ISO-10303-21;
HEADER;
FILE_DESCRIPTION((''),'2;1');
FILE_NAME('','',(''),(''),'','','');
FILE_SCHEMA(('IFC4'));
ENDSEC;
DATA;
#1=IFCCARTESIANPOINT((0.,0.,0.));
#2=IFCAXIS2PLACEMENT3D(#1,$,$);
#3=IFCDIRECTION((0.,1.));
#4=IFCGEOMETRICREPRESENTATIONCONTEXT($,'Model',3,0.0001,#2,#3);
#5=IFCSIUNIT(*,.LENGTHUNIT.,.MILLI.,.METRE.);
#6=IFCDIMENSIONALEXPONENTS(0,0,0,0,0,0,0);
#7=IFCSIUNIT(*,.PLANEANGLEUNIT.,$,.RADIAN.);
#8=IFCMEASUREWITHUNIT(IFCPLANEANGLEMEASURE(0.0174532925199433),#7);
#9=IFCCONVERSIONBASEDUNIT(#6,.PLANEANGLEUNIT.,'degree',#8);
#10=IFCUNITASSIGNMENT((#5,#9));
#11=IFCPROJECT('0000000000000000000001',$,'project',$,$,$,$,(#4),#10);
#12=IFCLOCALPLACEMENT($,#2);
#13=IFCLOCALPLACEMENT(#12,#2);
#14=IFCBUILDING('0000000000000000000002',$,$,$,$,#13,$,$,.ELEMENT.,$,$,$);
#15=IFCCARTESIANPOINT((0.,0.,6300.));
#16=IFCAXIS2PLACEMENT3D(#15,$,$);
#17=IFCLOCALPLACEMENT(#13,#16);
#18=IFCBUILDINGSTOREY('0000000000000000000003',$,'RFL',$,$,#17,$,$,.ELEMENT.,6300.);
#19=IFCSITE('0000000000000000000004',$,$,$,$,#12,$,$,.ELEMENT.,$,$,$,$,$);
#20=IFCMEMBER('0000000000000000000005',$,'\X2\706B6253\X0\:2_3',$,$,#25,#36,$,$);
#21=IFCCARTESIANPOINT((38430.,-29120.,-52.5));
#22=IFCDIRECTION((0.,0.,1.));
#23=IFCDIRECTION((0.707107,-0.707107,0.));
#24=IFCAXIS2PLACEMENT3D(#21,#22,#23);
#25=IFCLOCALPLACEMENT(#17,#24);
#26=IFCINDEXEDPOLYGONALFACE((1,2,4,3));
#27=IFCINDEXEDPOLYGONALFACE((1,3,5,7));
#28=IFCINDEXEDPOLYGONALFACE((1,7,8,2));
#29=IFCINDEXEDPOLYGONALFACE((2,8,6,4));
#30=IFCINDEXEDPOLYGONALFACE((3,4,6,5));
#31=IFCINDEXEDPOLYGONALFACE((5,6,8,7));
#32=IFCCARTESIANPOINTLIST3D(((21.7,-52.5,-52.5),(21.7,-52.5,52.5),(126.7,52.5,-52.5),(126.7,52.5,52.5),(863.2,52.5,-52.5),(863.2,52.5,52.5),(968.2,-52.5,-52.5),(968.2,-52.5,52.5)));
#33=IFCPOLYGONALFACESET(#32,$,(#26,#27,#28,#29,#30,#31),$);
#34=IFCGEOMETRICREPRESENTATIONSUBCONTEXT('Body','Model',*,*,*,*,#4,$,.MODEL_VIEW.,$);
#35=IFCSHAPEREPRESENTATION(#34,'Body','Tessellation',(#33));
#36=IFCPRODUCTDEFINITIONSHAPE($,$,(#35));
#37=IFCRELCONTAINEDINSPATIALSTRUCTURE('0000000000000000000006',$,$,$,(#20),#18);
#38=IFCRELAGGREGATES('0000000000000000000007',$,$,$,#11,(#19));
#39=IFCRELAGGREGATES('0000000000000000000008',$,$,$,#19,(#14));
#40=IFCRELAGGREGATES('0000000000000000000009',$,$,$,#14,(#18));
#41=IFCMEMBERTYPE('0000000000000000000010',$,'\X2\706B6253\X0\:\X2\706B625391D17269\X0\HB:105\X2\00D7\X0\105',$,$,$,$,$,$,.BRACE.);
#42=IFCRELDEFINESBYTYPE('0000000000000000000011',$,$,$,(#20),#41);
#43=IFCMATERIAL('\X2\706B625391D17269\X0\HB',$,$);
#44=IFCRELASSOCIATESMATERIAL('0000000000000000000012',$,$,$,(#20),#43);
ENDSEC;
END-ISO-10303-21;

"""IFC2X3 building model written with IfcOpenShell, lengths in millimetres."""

from ifc_helpers import new_model, entity, si_unit, converted_unit, direction, frame, origin, place, context, subcontext, project, spatial, polyline, outline, extrude, material, type_object, element, save


model = new_model("IFC2X3")

# Units and contexts
model_context = context("Model", 3, precision=0.0001, world=origin(), true_north=direction((0.0, 1.0)))
body_context = subcontext(model_context, "Body", "Model", "MODEL_VIEW")
ifc_project = project(units=[si_unit("LENGTHUNIT", "METRE", prefix="MILLI"), converted_unit("PLANEANGLEUNIT", "degree", entity("IfcPlaneAngleMeasure", 0.0174532925199433), si_unit("PLANEANGLEUNIT", "RADIAN"), dimensions=[0, 0, 0, 0, 0, 0, 0])], contexts=[model_context])

# Site, building, storey
site_placement = place(None, origin())
site = spatial("IfcSite", under=ifc_project, at=site_placement, CompositionType="ELEMENT")
building_placement = place(site_placement, origin())
building = spatial("IfcBuilding", under=site, at=building_placement, CompositionType="ELEMENT")
storey_placement = place(building_placement, frame((0.0, 0.0, 6300.0)))
storey = spatial("IfcBuildingStorey", under=building, at=storey_placement, Name="RFL", CompositionType="ELEMENT", Elevation=6300.0)

# Member
ifc_material = material(Name="火打金物HB")
member_type = type_object("IfcMemberType", Name="火打:火打金物HB:105×105", PredefinedType="BRACE")
member_1_placement = place(storey_placement, frame((38430.0, -29120.0, -52.5), z_axis=(0.0, 0.0, 1.0), x_axis=(0.707107, -0.707107, 0.0)))
element("IfcMember", 1, at=member_1_placement, inside=storey, type_object=member_type, material=ifc_material, Name="火打:2_3", context=body_context, shape_type="SweptSolid", body=[
    extrude(outline(polyline([(21.7, -52.5, 0.0), (126.7, 52.5, 0.0), (863.2, 52.5, 0.0), (968.2, -52.5, 0.0), (21.7, -52.5, 0.0)])), frame((0.0, 0.0, -52.5), z_axis=(0.0, 0.0, 1.0), x_axis=(1.0, 0.0, 0.0)), (0.0, 0.0, 1.0), 105.0),
])

save(model, "model.ifc")
